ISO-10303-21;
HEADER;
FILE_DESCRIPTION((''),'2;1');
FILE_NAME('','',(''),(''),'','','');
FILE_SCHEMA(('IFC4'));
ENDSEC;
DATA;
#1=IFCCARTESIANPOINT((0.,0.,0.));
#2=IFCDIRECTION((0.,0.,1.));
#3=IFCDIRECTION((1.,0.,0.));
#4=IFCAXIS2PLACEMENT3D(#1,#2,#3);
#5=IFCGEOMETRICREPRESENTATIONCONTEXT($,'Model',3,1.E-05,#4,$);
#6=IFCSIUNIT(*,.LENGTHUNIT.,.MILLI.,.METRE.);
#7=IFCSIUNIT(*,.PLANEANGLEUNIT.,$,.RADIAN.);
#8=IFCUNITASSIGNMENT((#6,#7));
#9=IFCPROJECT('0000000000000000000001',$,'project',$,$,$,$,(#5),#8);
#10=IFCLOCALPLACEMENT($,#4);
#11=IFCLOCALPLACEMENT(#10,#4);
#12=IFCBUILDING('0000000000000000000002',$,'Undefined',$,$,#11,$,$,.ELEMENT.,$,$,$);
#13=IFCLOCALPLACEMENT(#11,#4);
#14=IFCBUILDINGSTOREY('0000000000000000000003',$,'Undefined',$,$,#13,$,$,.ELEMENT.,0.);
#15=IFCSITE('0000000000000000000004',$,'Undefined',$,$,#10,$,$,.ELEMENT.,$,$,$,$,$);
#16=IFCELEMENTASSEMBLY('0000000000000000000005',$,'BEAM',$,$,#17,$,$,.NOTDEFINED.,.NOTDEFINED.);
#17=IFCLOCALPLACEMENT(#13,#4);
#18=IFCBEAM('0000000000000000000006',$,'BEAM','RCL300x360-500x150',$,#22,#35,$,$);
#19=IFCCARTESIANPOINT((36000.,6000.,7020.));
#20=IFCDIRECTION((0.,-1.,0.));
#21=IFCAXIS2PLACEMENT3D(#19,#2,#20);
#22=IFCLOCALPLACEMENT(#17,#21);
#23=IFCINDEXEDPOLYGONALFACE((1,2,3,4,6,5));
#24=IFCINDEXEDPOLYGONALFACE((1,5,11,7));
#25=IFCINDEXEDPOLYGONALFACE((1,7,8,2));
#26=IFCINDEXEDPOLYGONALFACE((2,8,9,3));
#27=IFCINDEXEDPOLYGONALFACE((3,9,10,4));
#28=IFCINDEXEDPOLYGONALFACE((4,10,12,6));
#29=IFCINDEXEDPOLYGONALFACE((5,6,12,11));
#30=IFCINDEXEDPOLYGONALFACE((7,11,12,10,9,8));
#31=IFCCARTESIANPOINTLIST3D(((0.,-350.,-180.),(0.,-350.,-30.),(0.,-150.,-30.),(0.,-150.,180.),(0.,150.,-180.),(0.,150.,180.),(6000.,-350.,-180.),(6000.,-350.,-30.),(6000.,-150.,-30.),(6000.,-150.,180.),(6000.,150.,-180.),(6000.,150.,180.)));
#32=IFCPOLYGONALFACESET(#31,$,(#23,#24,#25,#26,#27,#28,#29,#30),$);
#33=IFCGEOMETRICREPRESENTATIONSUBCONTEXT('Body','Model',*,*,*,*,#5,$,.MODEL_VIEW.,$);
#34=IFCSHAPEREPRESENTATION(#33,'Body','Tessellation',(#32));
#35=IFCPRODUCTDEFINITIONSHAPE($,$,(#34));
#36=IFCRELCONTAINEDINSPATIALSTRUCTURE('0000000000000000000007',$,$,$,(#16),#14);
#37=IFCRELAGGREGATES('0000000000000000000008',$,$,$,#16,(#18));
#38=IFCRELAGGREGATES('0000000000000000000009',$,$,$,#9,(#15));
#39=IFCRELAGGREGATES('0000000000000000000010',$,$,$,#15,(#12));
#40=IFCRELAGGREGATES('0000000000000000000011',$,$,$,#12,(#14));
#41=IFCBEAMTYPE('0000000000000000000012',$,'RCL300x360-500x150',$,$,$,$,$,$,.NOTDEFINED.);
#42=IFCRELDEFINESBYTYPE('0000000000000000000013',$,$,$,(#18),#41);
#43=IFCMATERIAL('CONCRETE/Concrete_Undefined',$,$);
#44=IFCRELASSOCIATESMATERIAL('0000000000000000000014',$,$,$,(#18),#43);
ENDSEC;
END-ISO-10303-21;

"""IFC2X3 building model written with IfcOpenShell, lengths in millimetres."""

from ifc_helpers import new_model, si_unit, frame, origin_with_axes, place, context, subcontext, project, spatial, polyline, outline, extrude, material, type_object, element, aggregate, save


model = new_model("IFC2X3")

# Units and contexts
model_context = context("Model", 3, precision=1e-05, world=origin_with_axes())
body_context = subcontext(model_context, "Body", "Model", "MODEL_VIEW")
ifc_project = project(units=[si_unit("LENGTHUNIT", "METRE", prefix="MILLI"), si_unit("PLANEANGLEUNIT", "RADIAN")], contexts=[model_context])

# Site, building, storey
site_placement = place(None, origin_with_axes())
site = spatial("IfcSite", under=ifc_project, at=site_placement, Name="Undefined", CompositionType="ELEMENT")
building_placement = place(site_placement, origin_with_axes())
building = spatial("IfcBuilding", under=site, at=building_placement, Name="Undefined", CompositionType="ELEMENT")
storey_placement = place(building_placement, origin_with_axes())
storey = spatial("IfcBuildingStorey", under=building, at=storey_placement, Name="Undefined", CompositionType="ELEMENT", Elevation=0.0)

# Shared definitions
ifc_material_1 = material(Name="CONCRETE/Concrete_Undefined")

# Element assembly, beam
assembly_1_placement = place(storey_placement, origin_with_axes())
assembly_1 = element("IfcElementAssembly", 1, at=assembly_1_placement, inside=storey, Name="BEAM", AssemblyPlace="NOTDEFINED", PredefinedType="NOTDEFINED")
beam_type = type_object("IfcBeamType", Name="RCL300x360-500x150", PredefinedType="NOTDEFINED")
beam_placement = place(assembly_1_placement, frame((36000.0, 6000.0, 7020.0), z_axis=(0.0, 0.0, 1.0), x_axis=(0.0, -1.0, 0.0)))
beam = element("IfcBeam", 2, at=beam_placement, type_object=beam_type, material=ifc_material_1, Name="BEAM", Description="RCL300x360-500x150", context=body_context, shape_type="SweptSolid", body=[
    extrude(outline(polyline([(350.0, -180.0), (-150.0, -180.0), (-150.0, 180.0), (150.0, 180.0), (150.0, -30.0), (350.0, -30.0), (350.0, -180.0)])), frame((6000.0, 0.0, 0.0), z_axis=(-1.0, 0.0, 0.0), x_axis=(0.0, -1.0, 0.0)), (0.0, 0.0, 1.0), 6000.0),
])
aggregate(assembly_1, [beam])

save(model, "model.ifc")
